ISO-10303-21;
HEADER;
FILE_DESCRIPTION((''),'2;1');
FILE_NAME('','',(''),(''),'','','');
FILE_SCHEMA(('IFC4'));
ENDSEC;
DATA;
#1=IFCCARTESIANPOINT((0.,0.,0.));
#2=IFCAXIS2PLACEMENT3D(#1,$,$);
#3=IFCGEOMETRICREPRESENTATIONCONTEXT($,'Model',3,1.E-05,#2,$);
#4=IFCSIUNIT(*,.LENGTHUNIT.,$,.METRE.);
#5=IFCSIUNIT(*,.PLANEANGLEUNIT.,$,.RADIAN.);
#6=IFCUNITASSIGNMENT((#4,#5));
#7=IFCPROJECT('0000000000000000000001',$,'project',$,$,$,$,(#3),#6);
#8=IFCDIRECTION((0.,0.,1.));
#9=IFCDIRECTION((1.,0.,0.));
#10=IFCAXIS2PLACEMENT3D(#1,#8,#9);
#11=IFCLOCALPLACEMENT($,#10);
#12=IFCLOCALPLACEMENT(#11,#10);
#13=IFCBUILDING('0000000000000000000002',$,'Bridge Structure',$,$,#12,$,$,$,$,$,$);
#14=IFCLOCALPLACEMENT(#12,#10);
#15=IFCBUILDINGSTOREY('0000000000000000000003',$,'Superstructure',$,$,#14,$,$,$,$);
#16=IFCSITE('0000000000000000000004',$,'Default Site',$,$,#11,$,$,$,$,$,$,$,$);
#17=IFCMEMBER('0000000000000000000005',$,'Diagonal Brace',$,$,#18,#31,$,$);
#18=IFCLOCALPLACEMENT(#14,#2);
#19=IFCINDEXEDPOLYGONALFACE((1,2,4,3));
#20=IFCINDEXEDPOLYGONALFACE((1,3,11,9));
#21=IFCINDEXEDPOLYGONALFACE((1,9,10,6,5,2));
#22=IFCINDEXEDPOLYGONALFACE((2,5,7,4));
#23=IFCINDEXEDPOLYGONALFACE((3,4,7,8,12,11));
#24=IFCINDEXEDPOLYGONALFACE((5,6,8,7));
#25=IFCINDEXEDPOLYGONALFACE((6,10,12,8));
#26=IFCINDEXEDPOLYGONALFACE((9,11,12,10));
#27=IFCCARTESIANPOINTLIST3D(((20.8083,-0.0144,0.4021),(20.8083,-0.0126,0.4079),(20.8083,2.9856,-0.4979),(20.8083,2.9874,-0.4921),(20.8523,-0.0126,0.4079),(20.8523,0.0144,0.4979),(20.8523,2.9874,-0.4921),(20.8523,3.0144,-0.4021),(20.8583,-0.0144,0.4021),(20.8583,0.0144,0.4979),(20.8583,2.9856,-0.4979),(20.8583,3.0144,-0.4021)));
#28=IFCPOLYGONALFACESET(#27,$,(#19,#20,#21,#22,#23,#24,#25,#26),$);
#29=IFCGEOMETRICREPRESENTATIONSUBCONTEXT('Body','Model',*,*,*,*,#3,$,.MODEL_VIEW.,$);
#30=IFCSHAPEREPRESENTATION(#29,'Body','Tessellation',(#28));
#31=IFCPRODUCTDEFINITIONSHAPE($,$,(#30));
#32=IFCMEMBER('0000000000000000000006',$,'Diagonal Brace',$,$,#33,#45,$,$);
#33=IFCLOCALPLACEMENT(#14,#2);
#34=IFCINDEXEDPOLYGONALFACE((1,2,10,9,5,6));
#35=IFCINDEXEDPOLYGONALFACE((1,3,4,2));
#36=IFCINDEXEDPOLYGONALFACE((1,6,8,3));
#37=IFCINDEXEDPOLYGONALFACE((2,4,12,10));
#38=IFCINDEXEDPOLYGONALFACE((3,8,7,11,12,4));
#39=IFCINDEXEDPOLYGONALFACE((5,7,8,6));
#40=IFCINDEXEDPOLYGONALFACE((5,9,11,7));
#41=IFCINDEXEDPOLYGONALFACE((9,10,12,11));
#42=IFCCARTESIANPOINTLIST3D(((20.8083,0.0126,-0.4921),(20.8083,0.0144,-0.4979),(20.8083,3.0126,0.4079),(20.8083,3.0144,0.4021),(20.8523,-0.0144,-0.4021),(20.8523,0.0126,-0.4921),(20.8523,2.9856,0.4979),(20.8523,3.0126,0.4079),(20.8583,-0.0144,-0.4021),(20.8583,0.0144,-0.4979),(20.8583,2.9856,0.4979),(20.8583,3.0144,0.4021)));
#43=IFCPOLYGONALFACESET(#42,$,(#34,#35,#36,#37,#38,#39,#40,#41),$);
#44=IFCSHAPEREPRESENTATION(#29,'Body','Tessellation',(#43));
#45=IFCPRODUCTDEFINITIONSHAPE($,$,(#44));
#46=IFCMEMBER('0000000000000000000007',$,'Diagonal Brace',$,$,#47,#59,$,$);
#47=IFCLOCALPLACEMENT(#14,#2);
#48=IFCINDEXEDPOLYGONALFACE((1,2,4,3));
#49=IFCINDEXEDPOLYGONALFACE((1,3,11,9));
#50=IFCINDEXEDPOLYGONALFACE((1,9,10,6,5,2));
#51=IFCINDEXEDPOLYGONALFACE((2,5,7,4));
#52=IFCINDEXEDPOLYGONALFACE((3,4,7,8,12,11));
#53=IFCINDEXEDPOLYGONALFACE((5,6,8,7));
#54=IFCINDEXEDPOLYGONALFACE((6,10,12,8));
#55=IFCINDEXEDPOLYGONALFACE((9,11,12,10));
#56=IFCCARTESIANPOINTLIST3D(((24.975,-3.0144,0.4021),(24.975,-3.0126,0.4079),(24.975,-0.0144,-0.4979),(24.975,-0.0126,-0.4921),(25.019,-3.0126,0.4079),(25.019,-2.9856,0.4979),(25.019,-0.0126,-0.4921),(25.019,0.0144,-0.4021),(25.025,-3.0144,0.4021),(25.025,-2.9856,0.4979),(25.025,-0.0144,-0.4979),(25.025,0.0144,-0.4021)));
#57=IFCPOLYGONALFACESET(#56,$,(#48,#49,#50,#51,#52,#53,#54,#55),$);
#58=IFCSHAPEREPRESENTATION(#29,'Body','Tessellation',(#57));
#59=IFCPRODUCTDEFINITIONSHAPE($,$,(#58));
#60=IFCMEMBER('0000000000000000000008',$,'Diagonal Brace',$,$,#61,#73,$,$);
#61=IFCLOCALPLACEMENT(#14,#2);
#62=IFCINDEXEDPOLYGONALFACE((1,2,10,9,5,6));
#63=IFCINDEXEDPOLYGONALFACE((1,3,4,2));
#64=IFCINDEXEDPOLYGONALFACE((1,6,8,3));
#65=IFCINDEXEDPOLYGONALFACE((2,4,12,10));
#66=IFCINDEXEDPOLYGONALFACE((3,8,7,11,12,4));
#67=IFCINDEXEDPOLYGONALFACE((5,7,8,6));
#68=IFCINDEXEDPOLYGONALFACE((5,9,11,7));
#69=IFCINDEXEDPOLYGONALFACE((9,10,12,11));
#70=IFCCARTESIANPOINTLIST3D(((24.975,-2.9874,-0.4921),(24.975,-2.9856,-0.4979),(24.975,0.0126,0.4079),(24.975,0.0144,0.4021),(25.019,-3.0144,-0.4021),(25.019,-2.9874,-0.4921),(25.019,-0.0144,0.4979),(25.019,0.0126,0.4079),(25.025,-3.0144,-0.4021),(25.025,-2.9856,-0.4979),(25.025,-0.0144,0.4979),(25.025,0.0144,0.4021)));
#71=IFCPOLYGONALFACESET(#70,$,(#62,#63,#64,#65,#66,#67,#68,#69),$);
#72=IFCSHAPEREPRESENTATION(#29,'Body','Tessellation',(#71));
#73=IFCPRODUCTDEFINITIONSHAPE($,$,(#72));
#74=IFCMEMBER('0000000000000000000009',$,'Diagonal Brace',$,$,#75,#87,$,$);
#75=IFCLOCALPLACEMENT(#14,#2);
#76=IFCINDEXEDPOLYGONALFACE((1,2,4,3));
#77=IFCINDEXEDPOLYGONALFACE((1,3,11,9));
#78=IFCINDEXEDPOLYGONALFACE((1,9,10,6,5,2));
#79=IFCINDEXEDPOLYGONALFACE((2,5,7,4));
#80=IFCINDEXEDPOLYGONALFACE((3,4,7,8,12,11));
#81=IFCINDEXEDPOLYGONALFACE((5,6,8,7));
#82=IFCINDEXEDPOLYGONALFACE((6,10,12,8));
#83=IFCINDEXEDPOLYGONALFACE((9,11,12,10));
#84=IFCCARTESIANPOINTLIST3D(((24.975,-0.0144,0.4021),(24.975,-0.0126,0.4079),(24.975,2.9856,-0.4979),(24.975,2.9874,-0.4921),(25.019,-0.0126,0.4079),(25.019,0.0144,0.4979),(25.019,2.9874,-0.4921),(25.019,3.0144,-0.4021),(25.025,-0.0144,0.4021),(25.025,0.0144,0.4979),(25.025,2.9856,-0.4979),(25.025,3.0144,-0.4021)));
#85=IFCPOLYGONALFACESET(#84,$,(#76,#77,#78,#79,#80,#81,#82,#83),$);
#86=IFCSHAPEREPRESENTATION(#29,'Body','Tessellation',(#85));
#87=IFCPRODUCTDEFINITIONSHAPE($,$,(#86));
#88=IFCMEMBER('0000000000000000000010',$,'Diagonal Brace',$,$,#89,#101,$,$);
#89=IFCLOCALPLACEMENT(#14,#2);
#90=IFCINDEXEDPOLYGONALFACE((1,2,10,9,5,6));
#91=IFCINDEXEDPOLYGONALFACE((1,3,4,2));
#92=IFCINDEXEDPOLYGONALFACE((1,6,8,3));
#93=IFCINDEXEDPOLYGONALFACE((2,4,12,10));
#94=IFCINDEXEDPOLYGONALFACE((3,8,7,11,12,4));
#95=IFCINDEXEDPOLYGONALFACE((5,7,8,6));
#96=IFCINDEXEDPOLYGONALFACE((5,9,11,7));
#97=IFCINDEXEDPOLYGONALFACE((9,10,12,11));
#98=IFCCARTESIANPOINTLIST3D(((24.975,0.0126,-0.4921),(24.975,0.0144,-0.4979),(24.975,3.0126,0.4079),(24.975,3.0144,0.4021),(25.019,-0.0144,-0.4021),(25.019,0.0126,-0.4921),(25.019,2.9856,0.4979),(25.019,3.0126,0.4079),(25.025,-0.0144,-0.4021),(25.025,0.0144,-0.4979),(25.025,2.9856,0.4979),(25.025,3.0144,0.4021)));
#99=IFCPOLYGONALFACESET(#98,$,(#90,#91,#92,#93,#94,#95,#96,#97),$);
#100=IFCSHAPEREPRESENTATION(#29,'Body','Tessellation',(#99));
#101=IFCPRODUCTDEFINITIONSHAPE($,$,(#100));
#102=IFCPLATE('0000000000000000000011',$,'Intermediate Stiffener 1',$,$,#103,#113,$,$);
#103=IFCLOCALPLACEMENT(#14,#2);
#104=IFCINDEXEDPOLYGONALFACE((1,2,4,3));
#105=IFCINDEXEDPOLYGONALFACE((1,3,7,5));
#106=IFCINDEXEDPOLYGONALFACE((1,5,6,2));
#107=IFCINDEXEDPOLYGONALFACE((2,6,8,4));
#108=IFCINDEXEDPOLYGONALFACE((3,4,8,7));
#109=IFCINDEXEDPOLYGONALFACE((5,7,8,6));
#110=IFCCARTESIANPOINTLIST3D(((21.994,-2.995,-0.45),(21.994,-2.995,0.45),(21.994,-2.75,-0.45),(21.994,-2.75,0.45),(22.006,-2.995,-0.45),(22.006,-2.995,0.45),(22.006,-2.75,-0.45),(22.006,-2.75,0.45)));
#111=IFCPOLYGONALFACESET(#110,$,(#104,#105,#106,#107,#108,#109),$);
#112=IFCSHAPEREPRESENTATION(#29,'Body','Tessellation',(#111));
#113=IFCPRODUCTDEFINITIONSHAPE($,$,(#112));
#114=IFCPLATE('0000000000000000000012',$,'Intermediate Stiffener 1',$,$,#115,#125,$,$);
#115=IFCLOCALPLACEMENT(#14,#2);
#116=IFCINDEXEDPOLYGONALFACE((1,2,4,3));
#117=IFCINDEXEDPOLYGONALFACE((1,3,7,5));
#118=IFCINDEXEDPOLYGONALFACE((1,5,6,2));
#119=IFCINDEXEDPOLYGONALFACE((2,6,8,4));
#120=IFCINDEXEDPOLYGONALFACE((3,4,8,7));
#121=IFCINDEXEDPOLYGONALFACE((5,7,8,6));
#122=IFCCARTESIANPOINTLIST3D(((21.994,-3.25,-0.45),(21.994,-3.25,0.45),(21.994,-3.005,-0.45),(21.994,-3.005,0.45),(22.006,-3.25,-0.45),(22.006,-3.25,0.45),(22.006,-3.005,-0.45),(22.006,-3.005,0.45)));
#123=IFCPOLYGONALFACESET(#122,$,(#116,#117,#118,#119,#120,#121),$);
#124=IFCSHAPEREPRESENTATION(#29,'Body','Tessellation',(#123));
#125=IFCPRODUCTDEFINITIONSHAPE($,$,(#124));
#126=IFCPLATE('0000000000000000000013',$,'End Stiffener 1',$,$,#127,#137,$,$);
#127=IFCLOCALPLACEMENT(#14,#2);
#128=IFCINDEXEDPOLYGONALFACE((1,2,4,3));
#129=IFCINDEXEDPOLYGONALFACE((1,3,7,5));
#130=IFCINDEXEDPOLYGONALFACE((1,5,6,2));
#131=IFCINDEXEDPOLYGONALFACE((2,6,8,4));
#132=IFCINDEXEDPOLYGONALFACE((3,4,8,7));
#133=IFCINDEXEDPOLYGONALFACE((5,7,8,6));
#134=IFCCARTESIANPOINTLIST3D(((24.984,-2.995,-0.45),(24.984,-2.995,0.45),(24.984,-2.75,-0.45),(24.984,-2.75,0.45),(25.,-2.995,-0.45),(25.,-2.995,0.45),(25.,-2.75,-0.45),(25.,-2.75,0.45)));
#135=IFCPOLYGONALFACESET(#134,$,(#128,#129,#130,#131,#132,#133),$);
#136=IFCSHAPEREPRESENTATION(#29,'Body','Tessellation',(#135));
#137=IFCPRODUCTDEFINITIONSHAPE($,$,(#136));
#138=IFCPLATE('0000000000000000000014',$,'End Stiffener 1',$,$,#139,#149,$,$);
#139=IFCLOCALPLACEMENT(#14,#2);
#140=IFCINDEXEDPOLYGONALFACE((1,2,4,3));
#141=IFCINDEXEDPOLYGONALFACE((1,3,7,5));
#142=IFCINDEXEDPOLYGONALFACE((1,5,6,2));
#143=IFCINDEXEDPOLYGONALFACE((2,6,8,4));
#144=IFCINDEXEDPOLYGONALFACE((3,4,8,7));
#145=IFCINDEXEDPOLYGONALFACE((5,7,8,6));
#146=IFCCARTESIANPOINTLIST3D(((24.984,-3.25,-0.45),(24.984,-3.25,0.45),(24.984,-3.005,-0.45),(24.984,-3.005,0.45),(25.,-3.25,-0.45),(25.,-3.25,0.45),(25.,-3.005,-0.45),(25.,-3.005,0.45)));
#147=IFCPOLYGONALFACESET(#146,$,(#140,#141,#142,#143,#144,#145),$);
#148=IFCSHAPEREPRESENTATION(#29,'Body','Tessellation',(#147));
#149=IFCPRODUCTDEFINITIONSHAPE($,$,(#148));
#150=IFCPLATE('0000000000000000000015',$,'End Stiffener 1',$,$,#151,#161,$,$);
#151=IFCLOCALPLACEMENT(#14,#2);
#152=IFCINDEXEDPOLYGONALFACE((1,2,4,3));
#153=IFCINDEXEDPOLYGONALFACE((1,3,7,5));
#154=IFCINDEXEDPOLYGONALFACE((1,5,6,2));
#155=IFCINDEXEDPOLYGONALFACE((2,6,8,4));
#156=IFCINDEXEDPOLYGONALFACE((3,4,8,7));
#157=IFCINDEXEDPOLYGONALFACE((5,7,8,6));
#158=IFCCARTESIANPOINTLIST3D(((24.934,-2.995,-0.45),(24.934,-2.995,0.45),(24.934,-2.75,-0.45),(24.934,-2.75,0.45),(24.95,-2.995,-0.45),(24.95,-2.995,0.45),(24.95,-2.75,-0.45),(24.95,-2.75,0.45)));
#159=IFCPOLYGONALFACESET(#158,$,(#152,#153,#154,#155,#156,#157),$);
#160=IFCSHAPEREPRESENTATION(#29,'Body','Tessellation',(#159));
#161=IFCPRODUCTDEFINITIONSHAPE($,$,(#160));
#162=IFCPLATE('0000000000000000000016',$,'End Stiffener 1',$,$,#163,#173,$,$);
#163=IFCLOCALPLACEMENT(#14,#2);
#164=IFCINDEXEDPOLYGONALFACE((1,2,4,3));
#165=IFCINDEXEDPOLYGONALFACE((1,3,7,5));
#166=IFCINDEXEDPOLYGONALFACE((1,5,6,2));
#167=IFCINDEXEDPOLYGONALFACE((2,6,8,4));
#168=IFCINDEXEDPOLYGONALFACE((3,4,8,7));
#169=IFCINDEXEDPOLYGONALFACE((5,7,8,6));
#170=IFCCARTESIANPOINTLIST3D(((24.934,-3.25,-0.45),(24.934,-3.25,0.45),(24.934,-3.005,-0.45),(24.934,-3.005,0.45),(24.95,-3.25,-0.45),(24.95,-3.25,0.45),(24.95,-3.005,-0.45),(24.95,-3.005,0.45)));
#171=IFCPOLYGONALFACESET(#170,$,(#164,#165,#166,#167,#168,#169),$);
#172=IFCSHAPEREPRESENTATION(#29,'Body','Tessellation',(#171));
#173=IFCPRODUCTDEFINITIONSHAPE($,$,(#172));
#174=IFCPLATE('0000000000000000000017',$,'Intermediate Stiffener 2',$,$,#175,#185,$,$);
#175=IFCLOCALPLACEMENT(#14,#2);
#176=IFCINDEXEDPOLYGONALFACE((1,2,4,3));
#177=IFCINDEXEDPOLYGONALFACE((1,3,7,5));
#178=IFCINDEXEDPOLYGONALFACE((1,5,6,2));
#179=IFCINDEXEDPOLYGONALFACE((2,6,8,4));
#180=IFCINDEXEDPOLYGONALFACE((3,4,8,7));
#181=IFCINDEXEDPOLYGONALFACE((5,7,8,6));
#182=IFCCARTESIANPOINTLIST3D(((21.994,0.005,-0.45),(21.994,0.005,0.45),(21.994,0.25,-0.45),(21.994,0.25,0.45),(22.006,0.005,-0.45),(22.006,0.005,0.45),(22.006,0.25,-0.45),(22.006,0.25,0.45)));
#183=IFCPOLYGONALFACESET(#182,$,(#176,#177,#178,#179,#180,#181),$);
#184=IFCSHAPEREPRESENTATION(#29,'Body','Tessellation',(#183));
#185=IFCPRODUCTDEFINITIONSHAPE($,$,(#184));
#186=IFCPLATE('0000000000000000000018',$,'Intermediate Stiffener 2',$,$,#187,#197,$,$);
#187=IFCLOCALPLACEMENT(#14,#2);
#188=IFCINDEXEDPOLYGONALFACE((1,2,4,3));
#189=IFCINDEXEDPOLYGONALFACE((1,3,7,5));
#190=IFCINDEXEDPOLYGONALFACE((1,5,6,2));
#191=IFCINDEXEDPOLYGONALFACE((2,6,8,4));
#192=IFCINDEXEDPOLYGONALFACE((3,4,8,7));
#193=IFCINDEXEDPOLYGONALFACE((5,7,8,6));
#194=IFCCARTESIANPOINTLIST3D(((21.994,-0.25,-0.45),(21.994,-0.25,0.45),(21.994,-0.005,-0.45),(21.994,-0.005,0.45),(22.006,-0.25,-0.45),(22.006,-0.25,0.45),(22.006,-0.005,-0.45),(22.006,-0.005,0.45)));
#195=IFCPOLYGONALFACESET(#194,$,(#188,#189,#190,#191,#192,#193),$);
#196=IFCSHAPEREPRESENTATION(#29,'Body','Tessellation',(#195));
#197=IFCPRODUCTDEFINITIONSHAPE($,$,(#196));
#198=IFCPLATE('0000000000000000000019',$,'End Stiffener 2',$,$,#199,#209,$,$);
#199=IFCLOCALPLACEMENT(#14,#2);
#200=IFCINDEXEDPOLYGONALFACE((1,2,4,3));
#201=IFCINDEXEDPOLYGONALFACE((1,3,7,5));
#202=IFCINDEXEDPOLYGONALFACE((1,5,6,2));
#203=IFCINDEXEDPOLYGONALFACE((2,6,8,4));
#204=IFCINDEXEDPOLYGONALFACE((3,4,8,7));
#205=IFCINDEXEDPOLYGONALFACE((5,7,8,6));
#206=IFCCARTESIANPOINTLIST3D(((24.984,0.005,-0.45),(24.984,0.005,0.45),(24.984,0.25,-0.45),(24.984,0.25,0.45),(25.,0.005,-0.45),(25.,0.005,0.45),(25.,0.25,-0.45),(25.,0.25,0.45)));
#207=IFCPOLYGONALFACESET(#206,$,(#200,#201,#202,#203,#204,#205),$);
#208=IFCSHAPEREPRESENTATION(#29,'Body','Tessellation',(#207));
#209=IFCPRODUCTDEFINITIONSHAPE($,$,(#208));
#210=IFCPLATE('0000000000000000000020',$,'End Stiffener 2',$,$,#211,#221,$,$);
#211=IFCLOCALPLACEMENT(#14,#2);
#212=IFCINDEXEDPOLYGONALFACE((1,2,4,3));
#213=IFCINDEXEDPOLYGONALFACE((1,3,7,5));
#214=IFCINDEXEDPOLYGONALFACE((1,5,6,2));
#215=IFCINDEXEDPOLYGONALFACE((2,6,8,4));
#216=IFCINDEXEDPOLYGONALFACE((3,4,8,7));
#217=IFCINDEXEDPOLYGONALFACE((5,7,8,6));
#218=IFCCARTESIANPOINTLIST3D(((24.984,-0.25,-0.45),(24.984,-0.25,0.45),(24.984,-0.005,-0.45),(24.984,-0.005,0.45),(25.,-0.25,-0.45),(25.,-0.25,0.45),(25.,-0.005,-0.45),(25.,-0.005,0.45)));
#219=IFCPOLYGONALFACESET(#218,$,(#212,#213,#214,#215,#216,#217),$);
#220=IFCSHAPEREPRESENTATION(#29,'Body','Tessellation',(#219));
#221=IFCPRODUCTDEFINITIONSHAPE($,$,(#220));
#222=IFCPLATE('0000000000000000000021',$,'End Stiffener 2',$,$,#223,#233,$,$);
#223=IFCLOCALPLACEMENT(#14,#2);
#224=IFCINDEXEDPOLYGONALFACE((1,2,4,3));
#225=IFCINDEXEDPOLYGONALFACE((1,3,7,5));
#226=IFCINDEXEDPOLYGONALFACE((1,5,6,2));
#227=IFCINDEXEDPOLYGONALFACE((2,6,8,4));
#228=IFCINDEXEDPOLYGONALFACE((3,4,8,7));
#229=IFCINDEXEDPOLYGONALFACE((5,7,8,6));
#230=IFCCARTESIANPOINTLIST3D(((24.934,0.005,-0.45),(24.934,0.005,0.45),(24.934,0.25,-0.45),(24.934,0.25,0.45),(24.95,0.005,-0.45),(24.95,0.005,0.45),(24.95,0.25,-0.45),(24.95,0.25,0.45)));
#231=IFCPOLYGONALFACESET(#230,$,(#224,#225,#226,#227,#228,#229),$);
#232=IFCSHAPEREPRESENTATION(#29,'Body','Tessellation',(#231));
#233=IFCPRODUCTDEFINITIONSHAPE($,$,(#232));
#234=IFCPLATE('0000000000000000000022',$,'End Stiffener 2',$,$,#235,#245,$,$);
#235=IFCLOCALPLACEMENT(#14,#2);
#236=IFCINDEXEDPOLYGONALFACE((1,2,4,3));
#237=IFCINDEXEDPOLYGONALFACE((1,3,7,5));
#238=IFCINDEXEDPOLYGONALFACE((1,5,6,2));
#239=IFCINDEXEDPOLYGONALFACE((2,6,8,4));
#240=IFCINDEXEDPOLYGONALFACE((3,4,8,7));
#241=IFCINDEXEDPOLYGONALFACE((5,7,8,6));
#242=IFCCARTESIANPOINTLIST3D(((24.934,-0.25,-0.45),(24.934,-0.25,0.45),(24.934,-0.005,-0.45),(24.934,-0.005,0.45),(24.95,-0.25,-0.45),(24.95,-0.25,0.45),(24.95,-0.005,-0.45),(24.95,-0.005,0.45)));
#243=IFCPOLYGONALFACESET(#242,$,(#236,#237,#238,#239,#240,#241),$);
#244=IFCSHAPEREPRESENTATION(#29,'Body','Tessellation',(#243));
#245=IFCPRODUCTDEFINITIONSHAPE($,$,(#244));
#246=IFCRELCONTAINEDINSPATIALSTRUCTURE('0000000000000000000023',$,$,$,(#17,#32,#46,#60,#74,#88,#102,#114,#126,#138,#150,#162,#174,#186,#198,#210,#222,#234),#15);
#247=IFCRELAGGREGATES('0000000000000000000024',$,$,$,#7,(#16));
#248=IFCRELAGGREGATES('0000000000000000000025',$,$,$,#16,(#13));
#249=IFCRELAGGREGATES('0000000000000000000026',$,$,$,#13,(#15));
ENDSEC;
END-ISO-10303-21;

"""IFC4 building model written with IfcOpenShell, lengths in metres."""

from ifc_helpers import new_model, si_unit, frame, origin, origin_with_axes, origin_2d_with_axis, place, context, subcontext, project, spatial, rectangle, l_section, extrude, element, save


model = new_model("IFC4")

# Units and contexts
model_context = context("Model", 3, precision=1e-05, world=origin())
body_context = subcontext(model_context, "Body", "Model", "MODEL_VIEW")
ifc_project = project(units=[si_unit("LENGTHUNIT", "METRE"), si_unit("PLANEANGLEUNIT", "RADIAN")], contexts=[model_context])

# Site, building, storey
site_placement = place(None, origin_with_axes())
site = spatial("IfcSite", under=ifc_project, at=site_placement, Name="Default Site")
building_placement = place(site_placement, origin_with_axes())
building = spatial("IfcBuilding", under=site, at=building_placement, Name="Bridge Structure")
storey_placement = place(building_placement, origin_with_axes())
storey = spatial("IfcBuildingStorey", under=building, at=storey_placement, Name="Superstructure")

# Members
for number, where, z_axis, x_axis, name in (
    (1, (20.8333, 0.0, 0.45), (0.0, 0.957826, -0.287348), (-1.0, 0.0, 0.0), "Diagonal Brace"),
    (2, (20.8333, 0.0, -0.45), (0.0, 0.957826, 0.287348), (-1.0, 0.0, 0.0), "Diagonal Brace"),
    (3, (25.0, -3.0, 0.45), (0.0, 0.957826, -0.287348), (-1.0, 0.0, 0.0), "Diagonal Brace"),
    (4, (25.0, -3.0, -0.45), (0.0, 0.957826, 0.287348), (-1.0, 0.0, 0.0), "Diagonal Brace"),
    (5, (25.0, 0.0, 0.45), (0.0, 0.957826, -0.287348), (-1.0, 0.0, 0.0), "Diagonal Brace"),
    (6, (25.0, 0.0, -0.45), (0.0, 0.957826, 0.287348), (-1.0, 0.0, 0.0), "Diagonal Brace"),
):
    element("IfcMember", number, at=place(storey_placement, frame(where, z_axis=z_axis, x_axis=x_axis)), inside=storey, Name=name, context=body_context, shape_type="SweptSolid", body=[
        extrude(l_section(Depth=0.1, Width=0.05, Thickness=0.006, at=origin_2d_with_axis()), origin_with_axes(), (0.0, 0.0, 1.0), 3.1321),
    ])

# Plates
for number, where, z_axis, x_axis, name in (
    (7, (22.0, -2.8725, -0.45), (0.0, 0.0, 1.0), (1.0, 0.0, 0.0), "Intermediate Stiffener 1"),
    (8, (22.0, -3.1275, -0.45), (0.0, 0.0, 1.0), (1.0, 0.0, 0.0), "Intermediate Stiffener 1"),
):
    element("IfcPlate", number, at=place(storey_placement, frame(where, z_axis=z_axis, x_axis=x_axis)), inside=storey, Name=name, context=body_context, shape_type="SweptSolid", body=[
        extrude(rectangle(XDim=0.012, YDim=0.245, at=origin_2d_with_axis()), origin_with_axes(), (0.0, 0.0, 1.0), 0.9),
    ])
for number, where, z_axis, x_axis, name in (
    (9, (24.992, -2.8725, -0.45), (0.0, 0.0, 1.0), (1.0, 0.0, 0.0), "End Stiffener 1"),
    (10, (24.992, -3.1275, -0.45), (0.0, 0.0, 1.0), (1.0, 0.0, 0.0), "End Stiffener 1"),
    (11, (24.942, -2.8725, -0.45), (0.0, 0.0, 1.0), (1.0, 0.0, 0.0), "End Stiffener 1"),
    (12, (24.942, -3.1275, -0.45), (0.0, 0.0, 1.0), (1.0, 0.0, 0.0), "End Stiffener 1"),
):
    element("IfcPlate", number, at=place(storey_placement, frame(where, z_axis=z_axis, x_axis=x_axis)), inside=storey, Name=name, context=body_context, shape_type="SweptSolid", body=[
        extrude(rectangle(XDim=0.016, YDim=0.245, at=origin_2d_with_axis()), origin_with_axes(), (0.0, 0.0, 1.0), 0.9),
    ])
for number, where, z_axis, x_axis, name in (
    (13, (22.0, 0.1275, -0.45), (0.0, 0.0, 1.0), (1.0, 0.0, 0.0), "Intermediate Stiffener 2"),
    (14, (22.0, -0.1275, -0.45), (0.0, 0.0, 1.0), (1.0, 0.0, 0.0), "Intermediate Stiffener 2"),
):
    element("IfcPlate", number, at=place(storey_placement, frame(where, z_axis=z_axis, x_axis=x_axis)), inside=storey, Name=name, context=body_context, shape_type="SweptSolid", body=[
        extrude(rectangle(XDim=0.012, YDim=0.245, at=origin_2d_with_axis()), origin_with_axes(), (0.0, 0.0, 1.0), 0.9),
    ])
for number, where, z_axis, x_axis, name in (
    (15, (24.992, 0.1275, -0.45), (0.0, 0.0, 1.0), (1.0, 0.0, 0.0), "End Stiffener 2"),
    (16, (24.992, -0.1275, -0.45), (0.0, 0.0, 1.0), (1.0, 0.0, 0.0), "End Stiffener 2"),
    (17, (24.942, 0.1275, -0.45), (0.0, 0.0, 1.0), (1.0, 0.0, 0.0), "End Stiffener 2"),
    (18, (24.942, -0.1275, -0.45), (0.0, 0.0, 1.0), (1.0, 0.0, 0.0), "End Stiffener 2"),
):
    element("IfcPlate", number, at=place(storey_placement, frame(where, z_axis=z_axis, x_axis=x_axis)), inside=storey, Name=name, context=body_context, shape_type="SweptSolid", body=[
        extrude(rectangle(XDim=0.016, YDim=0.245, at=origin_2d_with_axis()), origin_with_axes(), (0.0, 0.0, 1.0), 0.9),
    ])

save(model, "model.ifc")
